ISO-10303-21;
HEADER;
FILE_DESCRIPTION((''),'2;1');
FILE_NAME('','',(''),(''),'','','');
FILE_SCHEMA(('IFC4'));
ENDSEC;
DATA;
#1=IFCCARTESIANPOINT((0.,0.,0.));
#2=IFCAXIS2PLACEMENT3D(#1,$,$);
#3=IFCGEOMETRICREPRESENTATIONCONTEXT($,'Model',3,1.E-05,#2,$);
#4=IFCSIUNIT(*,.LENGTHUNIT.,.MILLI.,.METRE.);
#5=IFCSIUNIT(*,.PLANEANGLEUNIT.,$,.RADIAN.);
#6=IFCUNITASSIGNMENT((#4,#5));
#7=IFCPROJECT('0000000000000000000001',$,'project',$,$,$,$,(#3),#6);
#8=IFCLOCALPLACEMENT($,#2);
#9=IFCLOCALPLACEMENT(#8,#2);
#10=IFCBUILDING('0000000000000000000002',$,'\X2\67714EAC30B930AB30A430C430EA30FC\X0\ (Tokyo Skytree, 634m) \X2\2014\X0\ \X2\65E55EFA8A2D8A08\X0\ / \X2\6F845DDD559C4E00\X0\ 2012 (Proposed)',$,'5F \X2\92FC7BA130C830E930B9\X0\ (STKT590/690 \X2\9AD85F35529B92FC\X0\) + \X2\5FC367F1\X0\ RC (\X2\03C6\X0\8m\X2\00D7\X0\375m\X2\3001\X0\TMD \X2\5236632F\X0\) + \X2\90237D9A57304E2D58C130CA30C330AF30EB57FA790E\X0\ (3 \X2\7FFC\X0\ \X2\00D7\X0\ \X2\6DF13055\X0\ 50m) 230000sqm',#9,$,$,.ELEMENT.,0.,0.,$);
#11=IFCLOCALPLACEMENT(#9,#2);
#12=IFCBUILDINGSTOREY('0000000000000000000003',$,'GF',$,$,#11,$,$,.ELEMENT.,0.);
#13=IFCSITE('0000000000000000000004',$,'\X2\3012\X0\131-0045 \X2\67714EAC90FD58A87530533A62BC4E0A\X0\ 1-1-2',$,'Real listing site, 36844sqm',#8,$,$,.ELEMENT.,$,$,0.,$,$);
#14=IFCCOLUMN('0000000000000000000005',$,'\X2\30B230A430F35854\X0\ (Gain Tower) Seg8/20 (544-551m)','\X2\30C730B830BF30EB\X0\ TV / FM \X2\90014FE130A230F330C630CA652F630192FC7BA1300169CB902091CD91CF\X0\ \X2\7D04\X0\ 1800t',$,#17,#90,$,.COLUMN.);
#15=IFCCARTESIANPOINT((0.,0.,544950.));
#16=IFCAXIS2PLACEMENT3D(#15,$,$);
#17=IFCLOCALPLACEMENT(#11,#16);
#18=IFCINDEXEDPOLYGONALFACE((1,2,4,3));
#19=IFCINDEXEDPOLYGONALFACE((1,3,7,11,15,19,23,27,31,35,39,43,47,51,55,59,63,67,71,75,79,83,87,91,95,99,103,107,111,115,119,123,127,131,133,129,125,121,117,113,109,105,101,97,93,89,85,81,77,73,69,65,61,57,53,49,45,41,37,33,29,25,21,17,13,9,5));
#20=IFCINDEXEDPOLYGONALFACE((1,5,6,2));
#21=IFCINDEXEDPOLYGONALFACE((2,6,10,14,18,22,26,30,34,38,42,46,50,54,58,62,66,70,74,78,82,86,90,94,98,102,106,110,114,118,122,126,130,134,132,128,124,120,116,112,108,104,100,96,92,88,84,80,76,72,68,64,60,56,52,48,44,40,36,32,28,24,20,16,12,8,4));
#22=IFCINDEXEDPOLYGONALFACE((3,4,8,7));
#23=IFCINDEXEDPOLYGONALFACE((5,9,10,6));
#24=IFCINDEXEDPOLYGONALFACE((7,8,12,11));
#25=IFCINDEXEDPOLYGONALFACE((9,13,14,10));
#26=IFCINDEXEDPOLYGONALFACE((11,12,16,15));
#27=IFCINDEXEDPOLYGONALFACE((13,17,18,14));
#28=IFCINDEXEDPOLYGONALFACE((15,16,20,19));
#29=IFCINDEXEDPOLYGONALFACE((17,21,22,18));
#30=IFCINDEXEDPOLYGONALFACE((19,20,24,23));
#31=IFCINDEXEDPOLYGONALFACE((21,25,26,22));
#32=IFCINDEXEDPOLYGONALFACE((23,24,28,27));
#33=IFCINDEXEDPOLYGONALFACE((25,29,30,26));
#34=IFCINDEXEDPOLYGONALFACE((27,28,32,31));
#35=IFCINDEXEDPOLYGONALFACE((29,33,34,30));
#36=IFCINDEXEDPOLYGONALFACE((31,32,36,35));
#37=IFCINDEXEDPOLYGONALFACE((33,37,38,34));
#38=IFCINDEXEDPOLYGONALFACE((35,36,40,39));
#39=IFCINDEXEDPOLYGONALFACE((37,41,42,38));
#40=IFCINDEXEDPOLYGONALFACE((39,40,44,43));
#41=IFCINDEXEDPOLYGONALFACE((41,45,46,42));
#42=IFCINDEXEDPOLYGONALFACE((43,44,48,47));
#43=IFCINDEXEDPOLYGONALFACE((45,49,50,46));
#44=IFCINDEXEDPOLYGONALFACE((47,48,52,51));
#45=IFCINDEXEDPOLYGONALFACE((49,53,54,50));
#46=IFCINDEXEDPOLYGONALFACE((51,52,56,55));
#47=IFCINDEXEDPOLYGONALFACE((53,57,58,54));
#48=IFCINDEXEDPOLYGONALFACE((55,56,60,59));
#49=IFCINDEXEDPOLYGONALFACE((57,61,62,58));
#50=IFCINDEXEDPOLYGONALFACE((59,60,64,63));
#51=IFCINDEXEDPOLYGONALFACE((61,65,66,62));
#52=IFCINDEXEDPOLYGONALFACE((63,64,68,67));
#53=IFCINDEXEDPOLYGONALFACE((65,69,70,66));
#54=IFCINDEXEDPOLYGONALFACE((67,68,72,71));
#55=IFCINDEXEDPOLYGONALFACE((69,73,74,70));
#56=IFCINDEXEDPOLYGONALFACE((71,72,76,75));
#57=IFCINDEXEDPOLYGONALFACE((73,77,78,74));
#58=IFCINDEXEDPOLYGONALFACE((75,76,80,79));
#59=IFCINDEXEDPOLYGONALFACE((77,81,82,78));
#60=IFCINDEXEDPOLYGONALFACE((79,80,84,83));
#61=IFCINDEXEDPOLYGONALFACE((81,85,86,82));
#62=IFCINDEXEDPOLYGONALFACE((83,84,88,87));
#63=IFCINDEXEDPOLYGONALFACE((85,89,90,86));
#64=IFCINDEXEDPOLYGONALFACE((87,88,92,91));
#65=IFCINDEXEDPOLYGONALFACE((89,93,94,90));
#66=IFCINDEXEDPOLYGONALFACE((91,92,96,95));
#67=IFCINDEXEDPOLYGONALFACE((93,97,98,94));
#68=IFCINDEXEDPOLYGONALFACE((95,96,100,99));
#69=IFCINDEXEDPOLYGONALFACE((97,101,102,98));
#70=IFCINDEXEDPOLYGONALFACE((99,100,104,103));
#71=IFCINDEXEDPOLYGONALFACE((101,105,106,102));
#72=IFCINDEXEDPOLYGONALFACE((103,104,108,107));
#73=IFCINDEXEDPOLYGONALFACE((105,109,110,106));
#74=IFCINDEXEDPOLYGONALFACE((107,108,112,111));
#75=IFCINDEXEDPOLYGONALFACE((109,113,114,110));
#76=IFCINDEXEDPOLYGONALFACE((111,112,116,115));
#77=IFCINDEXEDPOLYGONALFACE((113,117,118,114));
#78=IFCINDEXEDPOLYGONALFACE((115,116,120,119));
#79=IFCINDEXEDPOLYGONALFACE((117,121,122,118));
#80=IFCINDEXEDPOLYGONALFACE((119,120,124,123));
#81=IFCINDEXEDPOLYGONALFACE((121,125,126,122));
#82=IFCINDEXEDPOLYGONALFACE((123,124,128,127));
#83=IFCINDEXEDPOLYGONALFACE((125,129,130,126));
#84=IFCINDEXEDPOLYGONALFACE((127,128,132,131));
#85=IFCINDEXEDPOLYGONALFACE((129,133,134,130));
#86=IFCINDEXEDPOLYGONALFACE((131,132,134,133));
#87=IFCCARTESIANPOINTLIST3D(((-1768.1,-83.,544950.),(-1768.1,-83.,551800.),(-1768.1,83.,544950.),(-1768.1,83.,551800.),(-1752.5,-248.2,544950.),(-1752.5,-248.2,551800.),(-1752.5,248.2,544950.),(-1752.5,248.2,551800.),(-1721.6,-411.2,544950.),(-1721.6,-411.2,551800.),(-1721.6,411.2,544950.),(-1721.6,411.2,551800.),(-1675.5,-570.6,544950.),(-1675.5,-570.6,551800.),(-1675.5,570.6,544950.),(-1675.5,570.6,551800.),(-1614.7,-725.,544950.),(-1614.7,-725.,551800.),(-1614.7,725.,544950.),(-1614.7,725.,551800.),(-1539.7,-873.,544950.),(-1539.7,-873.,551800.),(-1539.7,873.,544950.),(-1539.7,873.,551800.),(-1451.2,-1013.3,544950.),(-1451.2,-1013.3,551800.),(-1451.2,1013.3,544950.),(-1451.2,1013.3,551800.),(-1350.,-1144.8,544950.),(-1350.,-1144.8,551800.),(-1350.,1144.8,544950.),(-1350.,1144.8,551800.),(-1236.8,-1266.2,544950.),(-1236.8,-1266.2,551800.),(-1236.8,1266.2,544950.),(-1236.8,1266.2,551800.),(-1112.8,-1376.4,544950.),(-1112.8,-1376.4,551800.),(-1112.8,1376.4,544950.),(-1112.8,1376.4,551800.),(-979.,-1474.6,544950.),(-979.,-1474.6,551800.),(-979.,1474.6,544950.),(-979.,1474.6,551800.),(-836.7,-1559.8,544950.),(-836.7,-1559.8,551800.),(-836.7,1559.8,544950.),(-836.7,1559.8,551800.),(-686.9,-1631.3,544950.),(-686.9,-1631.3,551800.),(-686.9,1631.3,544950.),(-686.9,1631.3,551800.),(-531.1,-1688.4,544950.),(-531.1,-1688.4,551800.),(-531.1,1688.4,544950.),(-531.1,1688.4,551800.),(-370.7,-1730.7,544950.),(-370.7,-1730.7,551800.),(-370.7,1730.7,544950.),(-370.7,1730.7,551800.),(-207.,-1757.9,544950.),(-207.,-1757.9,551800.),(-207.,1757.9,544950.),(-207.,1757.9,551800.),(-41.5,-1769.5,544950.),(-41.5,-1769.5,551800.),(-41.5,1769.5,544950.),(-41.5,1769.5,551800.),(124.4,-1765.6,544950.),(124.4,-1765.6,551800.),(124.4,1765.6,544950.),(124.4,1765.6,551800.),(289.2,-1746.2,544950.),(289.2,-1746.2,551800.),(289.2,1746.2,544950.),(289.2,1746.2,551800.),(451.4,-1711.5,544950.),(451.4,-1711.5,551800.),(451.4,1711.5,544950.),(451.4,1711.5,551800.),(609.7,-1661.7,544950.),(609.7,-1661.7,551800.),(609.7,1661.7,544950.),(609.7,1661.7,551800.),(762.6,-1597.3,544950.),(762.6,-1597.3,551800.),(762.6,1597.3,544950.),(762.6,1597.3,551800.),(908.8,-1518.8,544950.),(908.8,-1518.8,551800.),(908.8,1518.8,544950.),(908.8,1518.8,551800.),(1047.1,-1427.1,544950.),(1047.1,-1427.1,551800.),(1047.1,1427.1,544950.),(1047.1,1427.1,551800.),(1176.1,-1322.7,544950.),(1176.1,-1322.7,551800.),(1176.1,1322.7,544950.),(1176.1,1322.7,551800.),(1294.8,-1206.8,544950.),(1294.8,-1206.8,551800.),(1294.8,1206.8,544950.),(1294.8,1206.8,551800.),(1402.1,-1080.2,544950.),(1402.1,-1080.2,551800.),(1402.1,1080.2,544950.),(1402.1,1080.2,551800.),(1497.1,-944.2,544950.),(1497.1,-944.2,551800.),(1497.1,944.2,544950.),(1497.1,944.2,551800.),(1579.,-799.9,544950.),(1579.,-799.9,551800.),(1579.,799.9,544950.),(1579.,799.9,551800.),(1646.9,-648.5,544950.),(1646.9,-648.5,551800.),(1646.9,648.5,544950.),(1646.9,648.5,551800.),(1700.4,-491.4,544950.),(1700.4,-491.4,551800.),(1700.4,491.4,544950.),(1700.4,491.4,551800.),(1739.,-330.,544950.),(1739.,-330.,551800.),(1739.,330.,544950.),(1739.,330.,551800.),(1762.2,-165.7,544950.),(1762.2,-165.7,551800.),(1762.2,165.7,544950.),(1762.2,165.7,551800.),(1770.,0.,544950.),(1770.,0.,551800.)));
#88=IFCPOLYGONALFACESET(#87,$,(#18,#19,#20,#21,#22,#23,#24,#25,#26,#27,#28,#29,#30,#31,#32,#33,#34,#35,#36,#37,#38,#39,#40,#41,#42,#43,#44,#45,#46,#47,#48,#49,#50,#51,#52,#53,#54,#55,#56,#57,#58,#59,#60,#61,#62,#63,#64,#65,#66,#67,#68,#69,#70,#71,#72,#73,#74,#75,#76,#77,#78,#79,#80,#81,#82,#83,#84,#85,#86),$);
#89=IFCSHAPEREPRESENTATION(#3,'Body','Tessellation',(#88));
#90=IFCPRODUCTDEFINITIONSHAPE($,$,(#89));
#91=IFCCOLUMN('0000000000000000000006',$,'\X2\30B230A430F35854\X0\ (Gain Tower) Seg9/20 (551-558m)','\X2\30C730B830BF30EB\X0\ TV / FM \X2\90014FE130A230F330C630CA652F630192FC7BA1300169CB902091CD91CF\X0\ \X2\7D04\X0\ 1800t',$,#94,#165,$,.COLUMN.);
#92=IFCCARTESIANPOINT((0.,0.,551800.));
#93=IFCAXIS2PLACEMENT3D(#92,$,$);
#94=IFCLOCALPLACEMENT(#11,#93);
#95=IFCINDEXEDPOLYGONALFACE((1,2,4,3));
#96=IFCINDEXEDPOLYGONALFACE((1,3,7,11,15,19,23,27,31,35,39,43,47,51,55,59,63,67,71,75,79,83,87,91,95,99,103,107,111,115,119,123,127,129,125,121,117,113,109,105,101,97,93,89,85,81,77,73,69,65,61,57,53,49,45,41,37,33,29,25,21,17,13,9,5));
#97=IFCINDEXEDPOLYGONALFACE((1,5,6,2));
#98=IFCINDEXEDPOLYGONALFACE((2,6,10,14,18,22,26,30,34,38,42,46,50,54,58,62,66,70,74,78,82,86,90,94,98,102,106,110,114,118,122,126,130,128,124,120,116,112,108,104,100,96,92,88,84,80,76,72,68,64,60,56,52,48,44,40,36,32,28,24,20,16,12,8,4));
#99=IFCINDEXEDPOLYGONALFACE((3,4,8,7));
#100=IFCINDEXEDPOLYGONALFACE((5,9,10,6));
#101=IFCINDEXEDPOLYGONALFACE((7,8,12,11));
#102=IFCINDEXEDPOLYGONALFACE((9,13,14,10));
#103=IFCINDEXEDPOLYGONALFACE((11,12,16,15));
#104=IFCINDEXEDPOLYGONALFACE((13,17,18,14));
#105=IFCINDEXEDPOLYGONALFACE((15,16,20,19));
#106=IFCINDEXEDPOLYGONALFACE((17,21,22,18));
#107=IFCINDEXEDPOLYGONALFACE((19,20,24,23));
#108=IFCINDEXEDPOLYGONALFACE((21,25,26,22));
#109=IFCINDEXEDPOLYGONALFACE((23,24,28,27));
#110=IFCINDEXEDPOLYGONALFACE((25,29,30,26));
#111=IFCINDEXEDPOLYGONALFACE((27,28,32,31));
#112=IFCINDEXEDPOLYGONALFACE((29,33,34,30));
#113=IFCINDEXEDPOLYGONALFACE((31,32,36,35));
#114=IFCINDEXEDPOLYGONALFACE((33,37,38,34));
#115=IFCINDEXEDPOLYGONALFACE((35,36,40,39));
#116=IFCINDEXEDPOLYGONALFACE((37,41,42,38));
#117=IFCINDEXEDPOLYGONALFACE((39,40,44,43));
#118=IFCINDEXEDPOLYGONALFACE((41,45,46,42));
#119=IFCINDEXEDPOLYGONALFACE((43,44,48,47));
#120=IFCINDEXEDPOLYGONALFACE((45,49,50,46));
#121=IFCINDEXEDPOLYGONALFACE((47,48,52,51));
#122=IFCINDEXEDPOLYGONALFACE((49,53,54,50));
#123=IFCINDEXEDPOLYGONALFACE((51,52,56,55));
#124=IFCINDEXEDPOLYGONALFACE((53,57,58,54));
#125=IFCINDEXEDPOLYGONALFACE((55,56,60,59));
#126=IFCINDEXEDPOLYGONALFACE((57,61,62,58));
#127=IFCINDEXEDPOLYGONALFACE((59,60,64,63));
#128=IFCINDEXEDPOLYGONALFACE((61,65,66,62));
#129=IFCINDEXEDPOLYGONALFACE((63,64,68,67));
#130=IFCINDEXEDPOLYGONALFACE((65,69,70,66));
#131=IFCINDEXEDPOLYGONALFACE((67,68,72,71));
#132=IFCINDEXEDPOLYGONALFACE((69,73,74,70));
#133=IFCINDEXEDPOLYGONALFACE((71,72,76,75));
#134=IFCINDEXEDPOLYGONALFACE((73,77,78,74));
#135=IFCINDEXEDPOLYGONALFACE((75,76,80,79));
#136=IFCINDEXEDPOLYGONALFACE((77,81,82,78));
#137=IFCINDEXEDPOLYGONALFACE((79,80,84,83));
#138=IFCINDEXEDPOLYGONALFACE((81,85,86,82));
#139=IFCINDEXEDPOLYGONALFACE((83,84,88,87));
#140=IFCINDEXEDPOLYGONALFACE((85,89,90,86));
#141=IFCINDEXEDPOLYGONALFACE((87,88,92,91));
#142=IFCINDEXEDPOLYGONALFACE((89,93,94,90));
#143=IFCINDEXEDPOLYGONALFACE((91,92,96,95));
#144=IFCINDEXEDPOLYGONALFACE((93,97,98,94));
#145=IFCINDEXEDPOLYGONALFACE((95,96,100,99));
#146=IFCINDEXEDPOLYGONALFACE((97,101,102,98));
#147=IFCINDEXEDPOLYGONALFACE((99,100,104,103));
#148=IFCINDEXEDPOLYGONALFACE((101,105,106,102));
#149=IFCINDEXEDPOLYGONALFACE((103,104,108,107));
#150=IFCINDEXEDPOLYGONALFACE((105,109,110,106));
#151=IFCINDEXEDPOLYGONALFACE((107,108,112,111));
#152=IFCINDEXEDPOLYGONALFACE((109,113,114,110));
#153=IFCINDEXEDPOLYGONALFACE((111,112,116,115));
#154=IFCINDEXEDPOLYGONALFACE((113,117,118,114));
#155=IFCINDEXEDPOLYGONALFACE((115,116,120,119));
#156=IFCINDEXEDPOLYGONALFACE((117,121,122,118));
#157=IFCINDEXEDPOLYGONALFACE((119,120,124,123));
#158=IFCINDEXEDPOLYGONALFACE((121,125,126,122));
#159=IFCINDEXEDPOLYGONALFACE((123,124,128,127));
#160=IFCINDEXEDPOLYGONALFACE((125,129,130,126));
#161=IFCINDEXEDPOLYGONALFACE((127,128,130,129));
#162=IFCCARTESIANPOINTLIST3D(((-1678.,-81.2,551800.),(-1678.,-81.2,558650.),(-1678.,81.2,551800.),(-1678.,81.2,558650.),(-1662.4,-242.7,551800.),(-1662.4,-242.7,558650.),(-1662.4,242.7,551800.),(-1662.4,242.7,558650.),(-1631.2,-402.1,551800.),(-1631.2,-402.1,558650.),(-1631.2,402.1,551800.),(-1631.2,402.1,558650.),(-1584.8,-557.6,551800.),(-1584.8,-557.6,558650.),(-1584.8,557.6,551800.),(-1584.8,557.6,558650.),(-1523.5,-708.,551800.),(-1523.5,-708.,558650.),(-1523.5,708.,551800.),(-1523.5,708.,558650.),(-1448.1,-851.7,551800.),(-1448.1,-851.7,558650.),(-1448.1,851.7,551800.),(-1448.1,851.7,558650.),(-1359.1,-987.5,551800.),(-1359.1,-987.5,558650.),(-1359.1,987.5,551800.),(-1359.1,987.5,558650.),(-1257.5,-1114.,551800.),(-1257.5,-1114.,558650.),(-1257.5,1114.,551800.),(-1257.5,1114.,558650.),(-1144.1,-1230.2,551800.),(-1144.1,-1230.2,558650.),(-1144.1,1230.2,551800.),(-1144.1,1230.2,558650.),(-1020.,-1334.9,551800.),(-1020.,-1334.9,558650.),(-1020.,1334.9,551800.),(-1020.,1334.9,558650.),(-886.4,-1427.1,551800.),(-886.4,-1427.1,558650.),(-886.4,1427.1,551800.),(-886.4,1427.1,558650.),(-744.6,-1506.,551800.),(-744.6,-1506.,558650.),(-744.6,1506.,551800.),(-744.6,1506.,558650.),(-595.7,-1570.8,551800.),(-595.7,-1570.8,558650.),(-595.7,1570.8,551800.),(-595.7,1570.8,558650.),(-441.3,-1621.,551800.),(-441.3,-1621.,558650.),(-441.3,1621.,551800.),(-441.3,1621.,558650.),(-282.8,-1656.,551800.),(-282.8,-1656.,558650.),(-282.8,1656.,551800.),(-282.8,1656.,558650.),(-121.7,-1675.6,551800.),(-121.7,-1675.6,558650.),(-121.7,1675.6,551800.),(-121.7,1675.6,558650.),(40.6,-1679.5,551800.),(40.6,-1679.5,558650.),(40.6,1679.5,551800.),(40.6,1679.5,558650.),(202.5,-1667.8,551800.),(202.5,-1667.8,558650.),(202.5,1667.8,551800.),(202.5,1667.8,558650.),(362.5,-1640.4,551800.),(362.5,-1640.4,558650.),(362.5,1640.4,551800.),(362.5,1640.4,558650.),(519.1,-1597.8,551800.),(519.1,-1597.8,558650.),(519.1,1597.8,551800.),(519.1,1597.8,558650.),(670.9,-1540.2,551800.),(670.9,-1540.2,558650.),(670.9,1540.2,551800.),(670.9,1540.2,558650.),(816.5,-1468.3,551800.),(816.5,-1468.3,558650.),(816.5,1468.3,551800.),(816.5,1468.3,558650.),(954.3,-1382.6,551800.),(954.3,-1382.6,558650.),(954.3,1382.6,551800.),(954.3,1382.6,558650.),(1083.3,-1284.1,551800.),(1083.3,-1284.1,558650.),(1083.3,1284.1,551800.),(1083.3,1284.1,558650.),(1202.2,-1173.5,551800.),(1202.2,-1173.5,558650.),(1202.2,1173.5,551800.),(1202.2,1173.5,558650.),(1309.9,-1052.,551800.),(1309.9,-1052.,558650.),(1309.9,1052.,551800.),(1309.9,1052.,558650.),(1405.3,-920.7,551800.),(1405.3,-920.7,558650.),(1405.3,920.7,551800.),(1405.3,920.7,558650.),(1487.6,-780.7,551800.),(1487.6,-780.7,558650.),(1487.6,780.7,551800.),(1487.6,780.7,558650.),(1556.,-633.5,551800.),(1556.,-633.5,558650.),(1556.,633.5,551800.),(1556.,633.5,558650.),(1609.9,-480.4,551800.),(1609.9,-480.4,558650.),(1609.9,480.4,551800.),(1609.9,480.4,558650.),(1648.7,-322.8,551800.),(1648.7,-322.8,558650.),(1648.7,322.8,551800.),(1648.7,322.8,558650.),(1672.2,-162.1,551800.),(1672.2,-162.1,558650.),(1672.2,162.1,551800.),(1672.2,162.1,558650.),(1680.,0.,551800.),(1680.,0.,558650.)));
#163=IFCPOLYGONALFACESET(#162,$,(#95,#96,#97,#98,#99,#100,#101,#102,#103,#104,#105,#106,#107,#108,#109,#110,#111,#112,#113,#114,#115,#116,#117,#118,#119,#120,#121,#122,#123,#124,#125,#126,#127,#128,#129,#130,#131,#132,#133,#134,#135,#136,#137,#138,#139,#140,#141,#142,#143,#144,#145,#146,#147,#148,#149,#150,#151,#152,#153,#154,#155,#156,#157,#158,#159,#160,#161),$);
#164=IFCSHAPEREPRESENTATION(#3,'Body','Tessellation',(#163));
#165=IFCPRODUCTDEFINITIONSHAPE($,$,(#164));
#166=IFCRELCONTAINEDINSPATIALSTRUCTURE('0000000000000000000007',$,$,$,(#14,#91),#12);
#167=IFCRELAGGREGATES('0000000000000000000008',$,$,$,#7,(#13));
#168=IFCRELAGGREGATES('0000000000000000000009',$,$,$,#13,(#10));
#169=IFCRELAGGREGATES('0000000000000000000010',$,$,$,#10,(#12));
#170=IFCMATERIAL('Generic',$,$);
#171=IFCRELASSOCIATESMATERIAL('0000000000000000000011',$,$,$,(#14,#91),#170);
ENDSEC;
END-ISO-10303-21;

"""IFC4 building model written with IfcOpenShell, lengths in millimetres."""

from ifc_helpers import new_model, si_unit, frame, origin, origin_2d, place, context, project, spatial, circle, extrude, material, element, save


model = new_model("IFC4")

# Units and contexts
model_context = context("Model", 3, precision=1e-05, world=origin())
ifc_project = project(units=[si_unit("LENGTHUNIT", "METRE", prefix="MILLI"), si_unit("PLANEANGLEUNIT", "RADIAN")], contexts=[model_context])

# Site, building, storey
site_placement = place(None, origin())
site = spatial("IfcSite", under=ifc_project, at=site_placement, Name="〒131-0045 東京都墨田区押上 1-1-2", ObjectType="Real listing site, 36844sqm", CompositionType="ELEMENT", RefElevation=0.0)
building_placement = place(site_placement, origin())
building = spatial("IfcBuilding", under=site, at=building_placement, Name="東京スカイツリー (Tokyo Skytree, 634m) — 日建設計 / 澄川喜一 2012 (Proposed)", ObjectType="5F 鋼管トラス (STKT590/690 高張力鋼) + 心柱 RC (φ8m×375m、TMD 制振) + 連続地中壁ナックル基礎 (3 翼 × 深さ 50m) 230000sqm", CompositionType="ELEMENT", ElevationOfRefHeight=0.0, ElevationOfTerrain=0.0)
storey_placement = place(building_placement, origin())
storey = spatial("IfcBuildingStorey", under=building, at=storey_placement, Name="GF", CompositionType="ELEMENT", Elevation=0.0)

# Columns
ifc_material = material(Name="Generic")
column_1_placement = place(storey_placement, frame((0.0, 0.0, 544950.0)))
element("IfcColumn", 1, at=column_1_placement, inside=storey, material=ifc_material, Name="ゲイン塔 (Gain Tower) Seg8/20 (544-551m)", Description="デジタル TV / FM 送信アンテナ支持鋼管、構造重量 約 1800t", PredefinedType="COLUMN", context=model_context, shape_type="SweptSolid", body=[
    extrude(circle(Radius=1770.0, at=origin_2d()), frame((0.0, 0.0, 544950.0)), (0.0, 0.0, 1.0), 6850.0),
])
column_2_placement = place(storey_placement, frame((0.0, 0.0, 551800.0)))
element("IfcColumn", 2, at=column_2_placement, inside=storey, material=ifc_material, Name="ゲイン塔 (Gain Tower) Seg9/20 (551-558m)", Description="デジタル TV / FM 送信アンテナ支持鋼管、構造重量 約 1800t", PredefinedType="COLUMN", context=model_context, shape_type="SweptSolid", body=[
    extrude(circle(Radius=1680.0, at=origin_2d()), frame((0.0, 0.0, 551800.0)), (0.0, 0.0, 1.0), 6850.0),
])

save(model, "model.ifc")
